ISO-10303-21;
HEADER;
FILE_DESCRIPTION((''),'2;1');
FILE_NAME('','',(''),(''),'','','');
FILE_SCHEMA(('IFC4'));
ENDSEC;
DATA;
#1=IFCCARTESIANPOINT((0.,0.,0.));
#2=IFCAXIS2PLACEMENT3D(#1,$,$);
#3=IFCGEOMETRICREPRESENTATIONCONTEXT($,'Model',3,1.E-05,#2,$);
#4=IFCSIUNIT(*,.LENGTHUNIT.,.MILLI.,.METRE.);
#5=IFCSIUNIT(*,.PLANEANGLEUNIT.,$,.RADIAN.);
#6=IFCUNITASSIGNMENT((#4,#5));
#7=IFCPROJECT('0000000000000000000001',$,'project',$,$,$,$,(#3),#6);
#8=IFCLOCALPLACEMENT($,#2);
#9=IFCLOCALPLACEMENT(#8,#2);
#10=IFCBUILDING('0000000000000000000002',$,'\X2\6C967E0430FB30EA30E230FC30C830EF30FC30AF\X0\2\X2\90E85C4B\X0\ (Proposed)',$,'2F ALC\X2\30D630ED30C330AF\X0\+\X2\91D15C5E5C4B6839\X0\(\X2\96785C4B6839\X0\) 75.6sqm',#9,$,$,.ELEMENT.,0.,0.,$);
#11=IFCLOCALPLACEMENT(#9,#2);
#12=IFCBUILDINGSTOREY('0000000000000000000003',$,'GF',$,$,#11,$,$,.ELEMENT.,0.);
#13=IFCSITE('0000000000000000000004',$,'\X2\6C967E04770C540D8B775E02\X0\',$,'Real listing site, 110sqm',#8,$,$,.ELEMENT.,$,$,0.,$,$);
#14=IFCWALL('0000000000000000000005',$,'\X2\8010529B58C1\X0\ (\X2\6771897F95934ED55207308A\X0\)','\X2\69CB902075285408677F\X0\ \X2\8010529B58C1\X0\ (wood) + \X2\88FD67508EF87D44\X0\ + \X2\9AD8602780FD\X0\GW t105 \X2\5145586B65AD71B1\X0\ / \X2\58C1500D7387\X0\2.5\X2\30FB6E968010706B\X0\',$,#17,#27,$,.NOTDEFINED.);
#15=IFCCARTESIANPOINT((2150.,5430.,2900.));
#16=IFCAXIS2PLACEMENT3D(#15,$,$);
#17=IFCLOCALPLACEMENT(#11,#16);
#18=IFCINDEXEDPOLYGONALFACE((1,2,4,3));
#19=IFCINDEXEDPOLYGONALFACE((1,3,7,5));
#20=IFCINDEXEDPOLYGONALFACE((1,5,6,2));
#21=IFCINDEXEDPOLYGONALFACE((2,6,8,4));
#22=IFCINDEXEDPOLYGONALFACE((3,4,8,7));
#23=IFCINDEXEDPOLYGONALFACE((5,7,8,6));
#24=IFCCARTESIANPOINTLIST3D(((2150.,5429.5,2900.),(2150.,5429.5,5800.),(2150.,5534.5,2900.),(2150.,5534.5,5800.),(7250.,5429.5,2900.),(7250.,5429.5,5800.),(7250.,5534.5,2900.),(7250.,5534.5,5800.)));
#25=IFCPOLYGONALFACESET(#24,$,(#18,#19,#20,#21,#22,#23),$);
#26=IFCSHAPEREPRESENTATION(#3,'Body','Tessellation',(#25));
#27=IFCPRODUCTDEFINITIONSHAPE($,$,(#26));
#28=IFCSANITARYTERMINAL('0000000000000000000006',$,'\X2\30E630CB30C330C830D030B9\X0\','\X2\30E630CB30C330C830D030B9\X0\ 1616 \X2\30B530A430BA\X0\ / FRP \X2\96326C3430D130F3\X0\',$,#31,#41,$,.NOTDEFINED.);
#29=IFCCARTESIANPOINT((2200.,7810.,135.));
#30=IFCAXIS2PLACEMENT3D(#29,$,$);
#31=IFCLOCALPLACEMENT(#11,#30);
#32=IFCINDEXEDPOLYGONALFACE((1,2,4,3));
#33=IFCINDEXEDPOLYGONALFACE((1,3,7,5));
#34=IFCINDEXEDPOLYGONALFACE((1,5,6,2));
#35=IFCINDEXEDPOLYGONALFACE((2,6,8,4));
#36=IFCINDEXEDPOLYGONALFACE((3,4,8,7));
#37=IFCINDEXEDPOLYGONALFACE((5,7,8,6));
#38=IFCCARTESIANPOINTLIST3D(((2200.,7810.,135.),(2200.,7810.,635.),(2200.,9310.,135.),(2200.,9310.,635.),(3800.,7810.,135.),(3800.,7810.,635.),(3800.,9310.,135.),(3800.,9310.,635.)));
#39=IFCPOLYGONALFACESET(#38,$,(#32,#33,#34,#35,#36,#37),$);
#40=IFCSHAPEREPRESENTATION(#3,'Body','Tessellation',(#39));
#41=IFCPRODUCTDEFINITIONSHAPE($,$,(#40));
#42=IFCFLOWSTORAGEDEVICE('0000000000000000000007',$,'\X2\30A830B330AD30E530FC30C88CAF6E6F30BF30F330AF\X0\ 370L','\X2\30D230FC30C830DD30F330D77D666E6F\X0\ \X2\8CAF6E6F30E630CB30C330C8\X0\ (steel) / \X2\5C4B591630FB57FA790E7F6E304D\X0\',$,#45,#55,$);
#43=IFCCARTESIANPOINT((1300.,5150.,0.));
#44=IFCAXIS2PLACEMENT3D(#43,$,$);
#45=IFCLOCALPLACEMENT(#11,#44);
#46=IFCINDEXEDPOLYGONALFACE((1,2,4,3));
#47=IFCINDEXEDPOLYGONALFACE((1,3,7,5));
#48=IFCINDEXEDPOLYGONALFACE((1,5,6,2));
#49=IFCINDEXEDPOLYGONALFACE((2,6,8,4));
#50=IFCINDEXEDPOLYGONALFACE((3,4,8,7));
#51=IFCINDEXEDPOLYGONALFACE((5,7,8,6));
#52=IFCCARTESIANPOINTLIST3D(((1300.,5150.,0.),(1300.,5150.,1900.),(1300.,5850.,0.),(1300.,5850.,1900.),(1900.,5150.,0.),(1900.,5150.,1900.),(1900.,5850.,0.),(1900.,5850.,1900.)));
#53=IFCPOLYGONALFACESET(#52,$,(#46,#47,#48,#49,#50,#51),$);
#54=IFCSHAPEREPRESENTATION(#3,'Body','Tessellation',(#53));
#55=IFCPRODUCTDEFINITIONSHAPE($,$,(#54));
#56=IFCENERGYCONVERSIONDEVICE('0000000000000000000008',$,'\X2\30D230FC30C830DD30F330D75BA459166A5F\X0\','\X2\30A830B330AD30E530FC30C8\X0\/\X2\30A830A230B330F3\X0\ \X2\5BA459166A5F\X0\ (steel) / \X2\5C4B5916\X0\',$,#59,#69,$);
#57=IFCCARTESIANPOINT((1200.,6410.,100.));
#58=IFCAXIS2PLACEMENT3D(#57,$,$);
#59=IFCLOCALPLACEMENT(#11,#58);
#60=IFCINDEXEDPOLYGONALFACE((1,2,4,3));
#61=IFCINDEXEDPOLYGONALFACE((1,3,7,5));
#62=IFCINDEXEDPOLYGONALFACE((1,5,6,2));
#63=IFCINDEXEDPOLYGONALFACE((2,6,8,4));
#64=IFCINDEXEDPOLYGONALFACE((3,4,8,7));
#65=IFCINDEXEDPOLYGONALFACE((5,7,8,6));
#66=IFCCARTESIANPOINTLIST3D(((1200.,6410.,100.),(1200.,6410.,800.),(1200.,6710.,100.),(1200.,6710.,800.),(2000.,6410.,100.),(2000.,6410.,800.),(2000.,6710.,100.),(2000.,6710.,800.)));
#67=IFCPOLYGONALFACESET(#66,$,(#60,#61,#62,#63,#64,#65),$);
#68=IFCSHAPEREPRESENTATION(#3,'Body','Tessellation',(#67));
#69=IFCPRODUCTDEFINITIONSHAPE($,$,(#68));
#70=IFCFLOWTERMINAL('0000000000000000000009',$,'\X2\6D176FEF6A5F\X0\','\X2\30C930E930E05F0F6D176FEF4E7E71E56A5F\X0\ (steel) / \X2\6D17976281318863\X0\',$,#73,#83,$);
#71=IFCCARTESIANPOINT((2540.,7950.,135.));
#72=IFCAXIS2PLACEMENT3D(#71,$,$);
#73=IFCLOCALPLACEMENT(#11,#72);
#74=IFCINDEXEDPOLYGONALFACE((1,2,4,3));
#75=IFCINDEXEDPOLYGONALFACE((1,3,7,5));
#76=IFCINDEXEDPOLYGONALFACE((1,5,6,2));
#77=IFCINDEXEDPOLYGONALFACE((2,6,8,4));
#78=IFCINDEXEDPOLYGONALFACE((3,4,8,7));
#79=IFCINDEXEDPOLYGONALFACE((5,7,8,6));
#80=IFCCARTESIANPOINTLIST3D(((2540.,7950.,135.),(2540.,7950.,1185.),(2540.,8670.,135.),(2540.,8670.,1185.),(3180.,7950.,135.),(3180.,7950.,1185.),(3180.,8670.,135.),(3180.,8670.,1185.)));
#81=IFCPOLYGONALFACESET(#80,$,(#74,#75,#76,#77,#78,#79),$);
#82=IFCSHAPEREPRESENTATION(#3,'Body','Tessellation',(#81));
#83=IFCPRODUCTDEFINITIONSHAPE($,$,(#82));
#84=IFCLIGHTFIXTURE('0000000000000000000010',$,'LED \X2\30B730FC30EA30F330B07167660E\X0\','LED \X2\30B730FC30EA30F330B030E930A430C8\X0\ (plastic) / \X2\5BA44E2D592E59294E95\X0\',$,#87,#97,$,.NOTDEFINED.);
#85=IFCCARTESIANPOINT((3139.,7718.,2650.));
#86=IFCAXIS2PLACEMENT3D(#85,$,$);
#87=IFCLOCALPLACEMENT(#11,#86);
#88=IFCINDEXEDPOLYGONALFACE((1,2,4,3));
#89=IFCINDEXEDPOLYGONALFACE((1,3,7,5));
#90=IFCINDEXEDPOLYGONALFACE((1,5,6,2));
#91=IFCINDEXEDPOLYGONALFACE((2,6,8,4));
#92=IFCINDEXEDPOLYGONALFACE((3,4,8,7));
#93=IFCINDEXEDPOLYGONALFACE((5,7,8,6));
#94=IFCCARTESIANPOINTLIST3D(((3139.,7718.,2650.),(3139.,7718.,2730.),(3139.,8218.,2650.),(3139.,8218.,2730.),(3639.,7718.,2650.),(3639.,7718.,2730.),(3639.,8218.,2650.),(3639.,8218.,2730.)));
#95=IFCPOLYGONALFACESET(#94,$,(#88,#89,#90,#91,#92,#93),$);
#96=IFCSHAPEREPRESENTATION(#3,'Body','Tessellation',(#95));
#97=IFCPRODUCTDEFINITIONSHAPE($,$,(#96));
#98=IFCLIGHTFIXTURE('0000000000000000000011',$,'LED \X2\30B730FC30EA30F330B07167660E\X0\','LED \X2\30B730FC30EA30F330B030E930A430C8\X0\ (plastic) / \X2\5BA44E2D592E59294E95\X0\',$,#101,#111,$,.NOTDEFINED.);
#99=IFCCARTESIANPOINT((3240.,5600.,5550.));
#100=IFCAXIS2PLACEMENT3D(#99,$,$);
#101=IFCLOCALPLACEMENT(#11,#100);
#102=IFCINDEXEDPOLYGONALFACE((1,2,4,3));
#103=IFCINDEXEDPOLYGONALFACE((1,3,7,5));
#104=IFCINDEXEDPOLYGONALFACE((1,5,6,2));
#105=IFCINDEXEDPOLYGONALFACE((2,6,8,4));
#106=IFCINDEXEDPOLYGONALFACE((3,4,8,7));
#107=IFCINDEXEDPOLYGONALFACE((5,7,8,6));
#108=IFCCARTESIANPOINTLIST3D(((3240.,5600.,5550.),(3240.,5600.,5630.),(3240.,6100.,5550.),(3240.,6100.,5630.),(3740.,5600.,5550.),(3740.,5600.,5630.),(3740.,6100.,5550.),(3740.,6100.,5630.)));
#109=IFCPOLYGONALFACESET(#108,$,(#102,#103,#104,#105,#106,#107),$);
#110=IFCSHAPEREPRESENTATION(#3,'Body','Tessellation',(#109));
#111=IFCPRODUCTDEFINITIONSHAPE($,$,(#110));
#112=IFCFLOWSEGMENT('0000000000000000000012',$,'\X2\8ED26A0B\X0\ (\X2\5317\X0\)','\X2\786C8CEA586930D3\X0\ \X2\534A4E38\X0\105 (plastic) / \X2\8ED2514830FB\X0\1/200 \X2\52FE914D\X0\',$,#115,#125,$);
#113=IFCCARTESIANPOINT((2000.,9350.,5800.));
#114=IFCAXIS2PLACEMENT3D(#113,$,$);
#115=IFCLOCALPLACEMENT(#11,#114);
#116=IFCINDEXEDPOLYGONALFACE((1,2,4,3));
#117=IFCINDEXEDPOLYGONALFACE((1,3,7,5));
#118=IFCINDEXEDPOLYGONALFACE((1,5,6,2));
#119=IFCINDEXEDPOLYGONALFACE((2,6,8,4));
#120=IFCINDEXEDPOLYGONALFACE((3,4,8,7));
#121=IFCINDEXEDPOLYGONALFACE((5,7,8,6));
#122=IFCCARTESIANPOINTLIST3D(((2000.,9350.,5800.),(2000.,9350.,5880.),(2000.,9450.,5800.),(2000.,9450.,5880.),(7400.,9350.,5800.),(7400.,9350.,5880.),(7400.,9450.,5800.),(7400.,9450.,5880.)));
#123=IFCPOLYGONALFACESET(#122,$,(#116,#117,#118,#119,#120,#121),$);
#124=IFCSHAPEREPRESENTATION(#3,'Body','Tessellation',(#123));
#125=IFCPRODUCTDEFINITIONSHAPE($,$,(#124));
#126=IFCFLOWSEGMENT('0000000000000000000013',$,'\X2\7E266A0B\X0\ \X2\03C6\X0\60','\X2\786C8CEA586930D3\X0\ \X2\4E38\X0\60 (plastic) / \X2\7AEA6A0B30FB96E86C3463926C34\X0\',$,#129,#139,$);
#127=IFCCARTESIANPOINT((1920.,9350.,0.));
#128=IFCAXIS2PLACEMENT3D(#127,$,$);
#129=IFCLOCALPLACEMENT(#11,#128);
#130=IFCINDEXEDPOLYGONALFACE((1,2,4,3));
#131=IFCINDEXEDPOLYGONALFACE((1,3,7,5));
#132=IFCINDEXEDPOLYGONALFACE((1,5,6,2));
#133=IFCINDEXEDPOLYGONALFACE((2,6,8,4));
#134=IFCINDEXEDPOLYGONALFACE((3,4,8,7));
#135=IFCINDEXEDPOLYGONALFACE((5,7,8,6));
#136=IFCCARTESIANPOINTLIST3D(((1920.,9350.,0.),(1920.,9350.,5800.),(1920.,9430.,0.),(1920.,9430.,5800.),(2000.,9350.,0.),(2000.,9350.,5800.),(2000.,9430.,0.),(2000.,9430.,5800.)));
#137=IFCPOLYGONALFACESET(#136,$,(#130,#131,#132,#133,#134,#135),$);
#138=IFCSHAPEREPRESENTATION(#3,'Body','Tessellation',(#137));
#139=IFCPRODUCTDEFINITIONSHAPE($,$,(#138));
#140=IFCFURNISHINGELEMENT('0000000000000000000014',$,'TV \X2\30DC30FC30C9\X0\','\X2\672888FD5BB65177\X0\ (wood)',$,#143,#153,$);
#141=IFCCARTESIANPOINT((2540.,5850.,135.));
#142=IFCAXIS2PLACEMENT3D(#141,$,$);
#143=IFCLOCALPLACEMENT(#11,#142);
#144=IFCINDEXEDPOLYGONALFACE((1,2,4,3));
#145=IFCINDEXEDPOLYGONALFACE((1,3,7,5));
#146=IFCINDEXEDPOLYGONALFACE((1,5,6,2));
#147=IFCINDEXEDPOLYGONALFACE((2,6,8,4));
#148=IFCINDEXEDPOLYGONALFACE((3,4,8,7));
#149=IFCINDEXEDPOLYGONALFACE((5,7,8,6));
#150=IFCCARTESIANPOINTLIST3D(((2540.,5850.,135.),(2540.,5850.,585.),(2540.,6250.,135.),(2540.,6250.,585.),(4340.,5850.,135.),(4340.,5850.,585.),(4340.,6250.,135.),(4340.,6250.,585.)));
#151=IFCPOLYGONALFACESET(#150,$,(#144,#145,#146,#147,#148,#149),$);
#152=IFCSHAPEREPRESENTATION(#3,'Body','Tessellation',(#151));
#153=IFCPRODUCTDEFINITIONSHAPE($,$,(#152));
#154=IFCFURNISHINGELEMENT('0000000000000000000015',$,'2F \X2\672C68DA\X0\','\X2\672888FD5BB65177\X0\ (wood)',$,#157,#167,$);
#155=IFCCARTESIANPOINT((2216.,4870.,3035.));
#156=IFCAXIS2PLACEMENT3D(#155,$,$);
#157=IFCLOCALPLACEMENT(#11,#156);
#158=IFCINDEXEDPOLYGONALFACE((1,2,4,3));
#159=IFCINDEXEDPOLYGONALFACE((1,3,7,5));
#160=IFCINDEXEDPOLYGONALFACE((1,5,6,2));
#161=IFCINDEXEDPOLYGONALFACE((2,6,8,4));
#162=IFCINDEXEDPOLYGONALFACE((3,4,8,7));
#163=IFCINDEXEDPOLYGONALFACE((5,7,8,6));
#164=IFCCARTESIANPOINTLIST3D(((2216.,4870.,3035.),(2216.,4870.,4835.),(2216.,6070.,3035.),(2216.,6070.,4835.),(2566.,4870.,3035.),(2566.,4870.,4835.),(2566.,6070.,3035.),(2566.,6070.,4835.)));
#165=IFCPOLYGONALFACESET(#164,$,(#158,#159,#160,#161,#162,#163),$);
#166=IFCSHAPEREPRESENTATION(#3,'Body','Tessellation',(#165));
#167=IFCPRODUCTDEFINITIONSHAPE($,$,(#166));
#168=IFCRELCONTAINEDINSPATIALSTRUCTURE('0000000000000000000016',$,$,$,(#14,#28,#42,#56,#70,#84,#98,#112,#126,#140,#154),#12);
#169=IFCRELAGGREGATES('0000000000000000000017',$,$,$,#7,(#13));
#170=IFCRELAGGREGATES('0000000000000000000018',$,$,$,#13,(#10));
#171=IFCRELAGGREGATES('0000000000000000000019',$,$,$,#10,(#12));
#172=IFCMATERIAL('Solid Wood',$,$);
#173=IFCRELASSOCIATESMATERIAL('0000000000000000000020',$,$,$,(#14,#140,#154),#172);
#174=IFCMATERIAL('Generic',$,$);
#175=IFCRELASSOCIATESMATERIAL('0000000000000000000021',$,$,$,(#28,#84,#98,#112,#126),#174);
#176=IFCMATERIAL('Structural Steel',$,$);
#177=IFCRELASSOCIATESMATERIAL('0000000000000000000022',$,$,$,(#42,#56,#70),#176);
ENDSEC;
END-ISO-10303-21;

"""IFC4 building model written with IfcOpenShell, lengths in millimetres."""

from ifc_helpers import new_model, si_unit, frame, frame_2d, origin, place, context, project, spatial, rectangle, extrude, material, element, save


model = new_model("IFC4")

# Units and contexts
model_context = context("Model", 3, precision=1e-05, world=origin())
ifc_project = project(units=[si_unit("LENGTHUNIT", "METRE", prefix="MILLI"), si_unit("PLANEANGLEUNIT", "RADIAN")], contexts=[model_context])

# Site, building, storey
site_placement = place(None, origin())
site = spatial("IfcSite", under=ifc_project, at=site_placement, Name="沖縄県名護市", ObjectType="Real listing site, 110sqm", CompositionType="ELEMENT", RefElevation=0.0)
building_placement = place(site_placement, origin())
building = spatial("IfcBuilding", under=site, at=building_placement, Name="沖縄・リモートワーク2部屋 (Proposed)", ObjectType="2F ALCブロック+金属屋根(陸屋根) 75.6sqm", CompositionType="ELEMENT", ElevationOfRefHeight=0.0, ElevationOfTerrain=0.0)
storey_placement = place(building_placement, origin())
storey = spatial("IfcBuildingStorey", under=building, at=storey_placement, Name="GF", CompositionType="ELEMENT", Elevation=0.0)

# Shared definitions
ifc_material_1 = material(Name="Solid Wood")

# Wall
wall_1_placement = place(storey_placement, frame((2150.0, 5430.0, 2900.0)))
element("IfcWall", 1, at=wall_1_placement, inside=storey, material=ifc_material_1, Name="耐力壁 (東西間仕切り)", Description="構造用合板 耐力壁 (wood) + 製材軸組 + 高性能GW t105 充填断熱 / 壁倍率2.5・準耐火", PredefinedType="NOTDEFINED", context=model_context, shape_type="SweptSolid", body=[
    extrude(rectangle(XDim=5100.0, YDim=105.0, at=frame_2d((2550.0, 52.0))), frame((2150.0, 5430.0, 2900.0)), (0.0, 0.0, 1.0), 2900.0),
])

# Sanitary terminal
ifc_material_2 = material(Name="Generic")
sanitary_terminal_placement = place(storey_placement, frame((2200.0, 7810.0, 135.0)))
element("IfcSanitaryTerminal", 2, at=sanitary_terminal_placement, inside=storey, material=ifc_material_2, Name="ユニットバス", Description="ユニットバス 1616 サイズ / FRP 防水パン", PredefinedType="NOTDEFINED", context=model_context, shape_type="SweptSolid", body=[
    extrude(rectangle(XDim=1600.0, YDim=1500.0, at=frame_2d((800.0, 750.0))), frame((2200.0, 7810.0, 135.0)), (0.0, 0.0, 1.0), 500.0),
])

# Flow storage device
ifc_material_3 = material(Name="Structural Steel")
flow_storage_device_placement = place(storey_placement, frame((1300.0, 5150.0, 0.0)))
element("IfcFlowStorageDevice", 3, at=flow_storage_device_placement, inside=storey, material=ifc_material_3, Name="エコキュート貯湯タンク 370L", Description="ヒートポンプ給湯 貯湯ユニット (steel) / 屋外・基礎置き", context=model_context, shape_type="SweptSolid", body=[
    extrude(rectangle(XDim=600.0, YDim=700.0, at=frame_2d((300.0, 350.0))), frame((1300.0, 5150.0, 0.0)), (0.0, 0.0, 1.0), 1900.0),
])

# Energy conversion device
energy_conversion_device_placement = place(storey_placement, frame((1200.0, 6410.0, 100.0)))
element("IfcEnergyConversionDevice", 4, at=energy_conversion_device_placement, inside=storey, material=ifc_material_3, Name="ヒートポンプ室外機", Description="エコキュート/エアコン 室外機 (steel) / 屋外", context=model_context, shape_type="SweptSolid", body=[
    extrude(rectangle(XDim=800.0, YDim=300.0, at=frame_2d((400.0, 150.0))), frame((1200.0, 6410.0, 100.0)), (0.0, 0.0, 1.0), 700.0),
])

# Flow terminal
flow_terminal_placement = place(storey_placement, frame((2540.0, 7950.0, 135.0)))
element("IfcFlowTerminal", 5, at=flow_terminal_placement, inside=storey, material=ifc_material_3, Name="洗濯機", Description="ドラム式洗濯乾燥機 (steel) / 洗面脱衣", context=model_context, shape_type="SweptSolid", body=[
    extrude(rectangle(XDim=640.0, YDim=720.0, at=frame_2d((320.0, 360.0))), frame((2540.0, 7950.0, 135.0)), (0.0, 0.0, 1.0), 1050.0),
])

# Light fixtures
light_fixture_1_placement = place(storey_placement, frame((3139.0, 7718.0, 2650.0)))
element("IfcLightFixture", 6, at=light_fixture_1_placement, inside=storey, material=ifc_material_2, Name="LED シーリング照明", Description="LED シーリングライト (plastic) / 室中央天井", PredefinedType="NOTDEFINED", context=model_context, shape_type="SweptSolid", body=[
    extrude(rectangle(XDim=500.0, YDim=500.0, at=frame_2d((250.0, 250.0))), frame((3139.0, 7718.0, 2650.0)), (0.0, 0.0, 1.0), 80.0),
])
light_fixture_2_placement = place(storey_placement, frame((3240.0, 5600.0, 5550.0)))
element("IfcLightFixture", 7, at=light_fixture_2_placement, inside=storey, material=ifc_material_2, Name="LED シーリング照明", Description="LED シーリングライト (plastic) / 室中央天井", PredefinedType="NOTDEFINED", context=model_context, shape_type="SweptSolid", body=[
    extrude(rectangle(XDim=500.0, YDim=500.0, at=frame_2d((250.0, 250.0))), frame((3240.0, 5600.0, 5550.0)), (0.0, 0.0, 1.0), 80.0),
])

# Flow segments
flow_segment_1_placement = place(storey_placement, frame((2000.0, 9350.0, 5800.0)))
element("IfcFlowSegment", 8, at=flow_segment_1_placement, inside=storey, material=ifc_material_2, Name="軒樋 (北)", Description="硬質塩ビ 半丸105 (plastic) / 軒先・1/200 勾配", context=model_context, shape_type="SweptSolid", body=[
    extrude(rectangle(XDim=5400.0, YDim=100.0, at=frame_2d((2700.0, 50.0))), frame((2000.0, 9350.0, 5800.0)), (0.0, 0.0, 1.0), 80.0),
])
flow_segment_2_placement = place(storey_placement, frame((1920.0, 9350.0, 0.0)))
element("IfcFlowSegment", 9, at=flow_segment_2_placement, inside=storey, material=ifc_material_2, Name="縦樋 φ60", Description="硬質塩ビ 丸60 (plastic) / 竪樋・雨水排水", context=model_context, shape_type="SweptSolid", body=[
    extrude(rectangle(XDim=80.0, YDim=80.0, at=frame_2d((40.0, 40.0))), frame((1920.0, 9350.0, 0.0)), (0.0, 0.0, 1.0), 5800.0),
])

# Furnishing elements
furnishing_1_placement = place(storey_placement, frame((2540.0, 5850.0, 135.0)))
element("IfcFurnishingElement", 10, at=furnishing_1_placement, inside=storey, material=ifc_material_1, Name="TV ボード", Description="木製家具 (wood)", context=model_context, shape_type="SweptSolid", body=[
    extrude(rectangle(XDim=1800.0, YDim=400.0, at=frame_2d((900.0, 200.0))), frame((2540.0, 5850.0, 135.0)), (0.0, 0.0, 1.0), 450.0),
])
furnishing_2_placement = place(storey_placement, frame((2216.0, 4870.0, 3035.0)))
element("IfcFurnishingElement", 11, at=furnishing_2_placement, inside=storey, material=ifc_material_1, Name="2F 本棚", Description="木製家具 (wood)", context=model_context, shape_type="SweptSolid", body=[
    extrude(rectangle(XDim=350.0, YDim=1200.0, at=frame_2d((175.0, 600.0))), frame((2216.0, 4870.0, 3035.0)), (0.0, 0.0, 1.0), 1800.0),
])

save(model, "model.ifc")
